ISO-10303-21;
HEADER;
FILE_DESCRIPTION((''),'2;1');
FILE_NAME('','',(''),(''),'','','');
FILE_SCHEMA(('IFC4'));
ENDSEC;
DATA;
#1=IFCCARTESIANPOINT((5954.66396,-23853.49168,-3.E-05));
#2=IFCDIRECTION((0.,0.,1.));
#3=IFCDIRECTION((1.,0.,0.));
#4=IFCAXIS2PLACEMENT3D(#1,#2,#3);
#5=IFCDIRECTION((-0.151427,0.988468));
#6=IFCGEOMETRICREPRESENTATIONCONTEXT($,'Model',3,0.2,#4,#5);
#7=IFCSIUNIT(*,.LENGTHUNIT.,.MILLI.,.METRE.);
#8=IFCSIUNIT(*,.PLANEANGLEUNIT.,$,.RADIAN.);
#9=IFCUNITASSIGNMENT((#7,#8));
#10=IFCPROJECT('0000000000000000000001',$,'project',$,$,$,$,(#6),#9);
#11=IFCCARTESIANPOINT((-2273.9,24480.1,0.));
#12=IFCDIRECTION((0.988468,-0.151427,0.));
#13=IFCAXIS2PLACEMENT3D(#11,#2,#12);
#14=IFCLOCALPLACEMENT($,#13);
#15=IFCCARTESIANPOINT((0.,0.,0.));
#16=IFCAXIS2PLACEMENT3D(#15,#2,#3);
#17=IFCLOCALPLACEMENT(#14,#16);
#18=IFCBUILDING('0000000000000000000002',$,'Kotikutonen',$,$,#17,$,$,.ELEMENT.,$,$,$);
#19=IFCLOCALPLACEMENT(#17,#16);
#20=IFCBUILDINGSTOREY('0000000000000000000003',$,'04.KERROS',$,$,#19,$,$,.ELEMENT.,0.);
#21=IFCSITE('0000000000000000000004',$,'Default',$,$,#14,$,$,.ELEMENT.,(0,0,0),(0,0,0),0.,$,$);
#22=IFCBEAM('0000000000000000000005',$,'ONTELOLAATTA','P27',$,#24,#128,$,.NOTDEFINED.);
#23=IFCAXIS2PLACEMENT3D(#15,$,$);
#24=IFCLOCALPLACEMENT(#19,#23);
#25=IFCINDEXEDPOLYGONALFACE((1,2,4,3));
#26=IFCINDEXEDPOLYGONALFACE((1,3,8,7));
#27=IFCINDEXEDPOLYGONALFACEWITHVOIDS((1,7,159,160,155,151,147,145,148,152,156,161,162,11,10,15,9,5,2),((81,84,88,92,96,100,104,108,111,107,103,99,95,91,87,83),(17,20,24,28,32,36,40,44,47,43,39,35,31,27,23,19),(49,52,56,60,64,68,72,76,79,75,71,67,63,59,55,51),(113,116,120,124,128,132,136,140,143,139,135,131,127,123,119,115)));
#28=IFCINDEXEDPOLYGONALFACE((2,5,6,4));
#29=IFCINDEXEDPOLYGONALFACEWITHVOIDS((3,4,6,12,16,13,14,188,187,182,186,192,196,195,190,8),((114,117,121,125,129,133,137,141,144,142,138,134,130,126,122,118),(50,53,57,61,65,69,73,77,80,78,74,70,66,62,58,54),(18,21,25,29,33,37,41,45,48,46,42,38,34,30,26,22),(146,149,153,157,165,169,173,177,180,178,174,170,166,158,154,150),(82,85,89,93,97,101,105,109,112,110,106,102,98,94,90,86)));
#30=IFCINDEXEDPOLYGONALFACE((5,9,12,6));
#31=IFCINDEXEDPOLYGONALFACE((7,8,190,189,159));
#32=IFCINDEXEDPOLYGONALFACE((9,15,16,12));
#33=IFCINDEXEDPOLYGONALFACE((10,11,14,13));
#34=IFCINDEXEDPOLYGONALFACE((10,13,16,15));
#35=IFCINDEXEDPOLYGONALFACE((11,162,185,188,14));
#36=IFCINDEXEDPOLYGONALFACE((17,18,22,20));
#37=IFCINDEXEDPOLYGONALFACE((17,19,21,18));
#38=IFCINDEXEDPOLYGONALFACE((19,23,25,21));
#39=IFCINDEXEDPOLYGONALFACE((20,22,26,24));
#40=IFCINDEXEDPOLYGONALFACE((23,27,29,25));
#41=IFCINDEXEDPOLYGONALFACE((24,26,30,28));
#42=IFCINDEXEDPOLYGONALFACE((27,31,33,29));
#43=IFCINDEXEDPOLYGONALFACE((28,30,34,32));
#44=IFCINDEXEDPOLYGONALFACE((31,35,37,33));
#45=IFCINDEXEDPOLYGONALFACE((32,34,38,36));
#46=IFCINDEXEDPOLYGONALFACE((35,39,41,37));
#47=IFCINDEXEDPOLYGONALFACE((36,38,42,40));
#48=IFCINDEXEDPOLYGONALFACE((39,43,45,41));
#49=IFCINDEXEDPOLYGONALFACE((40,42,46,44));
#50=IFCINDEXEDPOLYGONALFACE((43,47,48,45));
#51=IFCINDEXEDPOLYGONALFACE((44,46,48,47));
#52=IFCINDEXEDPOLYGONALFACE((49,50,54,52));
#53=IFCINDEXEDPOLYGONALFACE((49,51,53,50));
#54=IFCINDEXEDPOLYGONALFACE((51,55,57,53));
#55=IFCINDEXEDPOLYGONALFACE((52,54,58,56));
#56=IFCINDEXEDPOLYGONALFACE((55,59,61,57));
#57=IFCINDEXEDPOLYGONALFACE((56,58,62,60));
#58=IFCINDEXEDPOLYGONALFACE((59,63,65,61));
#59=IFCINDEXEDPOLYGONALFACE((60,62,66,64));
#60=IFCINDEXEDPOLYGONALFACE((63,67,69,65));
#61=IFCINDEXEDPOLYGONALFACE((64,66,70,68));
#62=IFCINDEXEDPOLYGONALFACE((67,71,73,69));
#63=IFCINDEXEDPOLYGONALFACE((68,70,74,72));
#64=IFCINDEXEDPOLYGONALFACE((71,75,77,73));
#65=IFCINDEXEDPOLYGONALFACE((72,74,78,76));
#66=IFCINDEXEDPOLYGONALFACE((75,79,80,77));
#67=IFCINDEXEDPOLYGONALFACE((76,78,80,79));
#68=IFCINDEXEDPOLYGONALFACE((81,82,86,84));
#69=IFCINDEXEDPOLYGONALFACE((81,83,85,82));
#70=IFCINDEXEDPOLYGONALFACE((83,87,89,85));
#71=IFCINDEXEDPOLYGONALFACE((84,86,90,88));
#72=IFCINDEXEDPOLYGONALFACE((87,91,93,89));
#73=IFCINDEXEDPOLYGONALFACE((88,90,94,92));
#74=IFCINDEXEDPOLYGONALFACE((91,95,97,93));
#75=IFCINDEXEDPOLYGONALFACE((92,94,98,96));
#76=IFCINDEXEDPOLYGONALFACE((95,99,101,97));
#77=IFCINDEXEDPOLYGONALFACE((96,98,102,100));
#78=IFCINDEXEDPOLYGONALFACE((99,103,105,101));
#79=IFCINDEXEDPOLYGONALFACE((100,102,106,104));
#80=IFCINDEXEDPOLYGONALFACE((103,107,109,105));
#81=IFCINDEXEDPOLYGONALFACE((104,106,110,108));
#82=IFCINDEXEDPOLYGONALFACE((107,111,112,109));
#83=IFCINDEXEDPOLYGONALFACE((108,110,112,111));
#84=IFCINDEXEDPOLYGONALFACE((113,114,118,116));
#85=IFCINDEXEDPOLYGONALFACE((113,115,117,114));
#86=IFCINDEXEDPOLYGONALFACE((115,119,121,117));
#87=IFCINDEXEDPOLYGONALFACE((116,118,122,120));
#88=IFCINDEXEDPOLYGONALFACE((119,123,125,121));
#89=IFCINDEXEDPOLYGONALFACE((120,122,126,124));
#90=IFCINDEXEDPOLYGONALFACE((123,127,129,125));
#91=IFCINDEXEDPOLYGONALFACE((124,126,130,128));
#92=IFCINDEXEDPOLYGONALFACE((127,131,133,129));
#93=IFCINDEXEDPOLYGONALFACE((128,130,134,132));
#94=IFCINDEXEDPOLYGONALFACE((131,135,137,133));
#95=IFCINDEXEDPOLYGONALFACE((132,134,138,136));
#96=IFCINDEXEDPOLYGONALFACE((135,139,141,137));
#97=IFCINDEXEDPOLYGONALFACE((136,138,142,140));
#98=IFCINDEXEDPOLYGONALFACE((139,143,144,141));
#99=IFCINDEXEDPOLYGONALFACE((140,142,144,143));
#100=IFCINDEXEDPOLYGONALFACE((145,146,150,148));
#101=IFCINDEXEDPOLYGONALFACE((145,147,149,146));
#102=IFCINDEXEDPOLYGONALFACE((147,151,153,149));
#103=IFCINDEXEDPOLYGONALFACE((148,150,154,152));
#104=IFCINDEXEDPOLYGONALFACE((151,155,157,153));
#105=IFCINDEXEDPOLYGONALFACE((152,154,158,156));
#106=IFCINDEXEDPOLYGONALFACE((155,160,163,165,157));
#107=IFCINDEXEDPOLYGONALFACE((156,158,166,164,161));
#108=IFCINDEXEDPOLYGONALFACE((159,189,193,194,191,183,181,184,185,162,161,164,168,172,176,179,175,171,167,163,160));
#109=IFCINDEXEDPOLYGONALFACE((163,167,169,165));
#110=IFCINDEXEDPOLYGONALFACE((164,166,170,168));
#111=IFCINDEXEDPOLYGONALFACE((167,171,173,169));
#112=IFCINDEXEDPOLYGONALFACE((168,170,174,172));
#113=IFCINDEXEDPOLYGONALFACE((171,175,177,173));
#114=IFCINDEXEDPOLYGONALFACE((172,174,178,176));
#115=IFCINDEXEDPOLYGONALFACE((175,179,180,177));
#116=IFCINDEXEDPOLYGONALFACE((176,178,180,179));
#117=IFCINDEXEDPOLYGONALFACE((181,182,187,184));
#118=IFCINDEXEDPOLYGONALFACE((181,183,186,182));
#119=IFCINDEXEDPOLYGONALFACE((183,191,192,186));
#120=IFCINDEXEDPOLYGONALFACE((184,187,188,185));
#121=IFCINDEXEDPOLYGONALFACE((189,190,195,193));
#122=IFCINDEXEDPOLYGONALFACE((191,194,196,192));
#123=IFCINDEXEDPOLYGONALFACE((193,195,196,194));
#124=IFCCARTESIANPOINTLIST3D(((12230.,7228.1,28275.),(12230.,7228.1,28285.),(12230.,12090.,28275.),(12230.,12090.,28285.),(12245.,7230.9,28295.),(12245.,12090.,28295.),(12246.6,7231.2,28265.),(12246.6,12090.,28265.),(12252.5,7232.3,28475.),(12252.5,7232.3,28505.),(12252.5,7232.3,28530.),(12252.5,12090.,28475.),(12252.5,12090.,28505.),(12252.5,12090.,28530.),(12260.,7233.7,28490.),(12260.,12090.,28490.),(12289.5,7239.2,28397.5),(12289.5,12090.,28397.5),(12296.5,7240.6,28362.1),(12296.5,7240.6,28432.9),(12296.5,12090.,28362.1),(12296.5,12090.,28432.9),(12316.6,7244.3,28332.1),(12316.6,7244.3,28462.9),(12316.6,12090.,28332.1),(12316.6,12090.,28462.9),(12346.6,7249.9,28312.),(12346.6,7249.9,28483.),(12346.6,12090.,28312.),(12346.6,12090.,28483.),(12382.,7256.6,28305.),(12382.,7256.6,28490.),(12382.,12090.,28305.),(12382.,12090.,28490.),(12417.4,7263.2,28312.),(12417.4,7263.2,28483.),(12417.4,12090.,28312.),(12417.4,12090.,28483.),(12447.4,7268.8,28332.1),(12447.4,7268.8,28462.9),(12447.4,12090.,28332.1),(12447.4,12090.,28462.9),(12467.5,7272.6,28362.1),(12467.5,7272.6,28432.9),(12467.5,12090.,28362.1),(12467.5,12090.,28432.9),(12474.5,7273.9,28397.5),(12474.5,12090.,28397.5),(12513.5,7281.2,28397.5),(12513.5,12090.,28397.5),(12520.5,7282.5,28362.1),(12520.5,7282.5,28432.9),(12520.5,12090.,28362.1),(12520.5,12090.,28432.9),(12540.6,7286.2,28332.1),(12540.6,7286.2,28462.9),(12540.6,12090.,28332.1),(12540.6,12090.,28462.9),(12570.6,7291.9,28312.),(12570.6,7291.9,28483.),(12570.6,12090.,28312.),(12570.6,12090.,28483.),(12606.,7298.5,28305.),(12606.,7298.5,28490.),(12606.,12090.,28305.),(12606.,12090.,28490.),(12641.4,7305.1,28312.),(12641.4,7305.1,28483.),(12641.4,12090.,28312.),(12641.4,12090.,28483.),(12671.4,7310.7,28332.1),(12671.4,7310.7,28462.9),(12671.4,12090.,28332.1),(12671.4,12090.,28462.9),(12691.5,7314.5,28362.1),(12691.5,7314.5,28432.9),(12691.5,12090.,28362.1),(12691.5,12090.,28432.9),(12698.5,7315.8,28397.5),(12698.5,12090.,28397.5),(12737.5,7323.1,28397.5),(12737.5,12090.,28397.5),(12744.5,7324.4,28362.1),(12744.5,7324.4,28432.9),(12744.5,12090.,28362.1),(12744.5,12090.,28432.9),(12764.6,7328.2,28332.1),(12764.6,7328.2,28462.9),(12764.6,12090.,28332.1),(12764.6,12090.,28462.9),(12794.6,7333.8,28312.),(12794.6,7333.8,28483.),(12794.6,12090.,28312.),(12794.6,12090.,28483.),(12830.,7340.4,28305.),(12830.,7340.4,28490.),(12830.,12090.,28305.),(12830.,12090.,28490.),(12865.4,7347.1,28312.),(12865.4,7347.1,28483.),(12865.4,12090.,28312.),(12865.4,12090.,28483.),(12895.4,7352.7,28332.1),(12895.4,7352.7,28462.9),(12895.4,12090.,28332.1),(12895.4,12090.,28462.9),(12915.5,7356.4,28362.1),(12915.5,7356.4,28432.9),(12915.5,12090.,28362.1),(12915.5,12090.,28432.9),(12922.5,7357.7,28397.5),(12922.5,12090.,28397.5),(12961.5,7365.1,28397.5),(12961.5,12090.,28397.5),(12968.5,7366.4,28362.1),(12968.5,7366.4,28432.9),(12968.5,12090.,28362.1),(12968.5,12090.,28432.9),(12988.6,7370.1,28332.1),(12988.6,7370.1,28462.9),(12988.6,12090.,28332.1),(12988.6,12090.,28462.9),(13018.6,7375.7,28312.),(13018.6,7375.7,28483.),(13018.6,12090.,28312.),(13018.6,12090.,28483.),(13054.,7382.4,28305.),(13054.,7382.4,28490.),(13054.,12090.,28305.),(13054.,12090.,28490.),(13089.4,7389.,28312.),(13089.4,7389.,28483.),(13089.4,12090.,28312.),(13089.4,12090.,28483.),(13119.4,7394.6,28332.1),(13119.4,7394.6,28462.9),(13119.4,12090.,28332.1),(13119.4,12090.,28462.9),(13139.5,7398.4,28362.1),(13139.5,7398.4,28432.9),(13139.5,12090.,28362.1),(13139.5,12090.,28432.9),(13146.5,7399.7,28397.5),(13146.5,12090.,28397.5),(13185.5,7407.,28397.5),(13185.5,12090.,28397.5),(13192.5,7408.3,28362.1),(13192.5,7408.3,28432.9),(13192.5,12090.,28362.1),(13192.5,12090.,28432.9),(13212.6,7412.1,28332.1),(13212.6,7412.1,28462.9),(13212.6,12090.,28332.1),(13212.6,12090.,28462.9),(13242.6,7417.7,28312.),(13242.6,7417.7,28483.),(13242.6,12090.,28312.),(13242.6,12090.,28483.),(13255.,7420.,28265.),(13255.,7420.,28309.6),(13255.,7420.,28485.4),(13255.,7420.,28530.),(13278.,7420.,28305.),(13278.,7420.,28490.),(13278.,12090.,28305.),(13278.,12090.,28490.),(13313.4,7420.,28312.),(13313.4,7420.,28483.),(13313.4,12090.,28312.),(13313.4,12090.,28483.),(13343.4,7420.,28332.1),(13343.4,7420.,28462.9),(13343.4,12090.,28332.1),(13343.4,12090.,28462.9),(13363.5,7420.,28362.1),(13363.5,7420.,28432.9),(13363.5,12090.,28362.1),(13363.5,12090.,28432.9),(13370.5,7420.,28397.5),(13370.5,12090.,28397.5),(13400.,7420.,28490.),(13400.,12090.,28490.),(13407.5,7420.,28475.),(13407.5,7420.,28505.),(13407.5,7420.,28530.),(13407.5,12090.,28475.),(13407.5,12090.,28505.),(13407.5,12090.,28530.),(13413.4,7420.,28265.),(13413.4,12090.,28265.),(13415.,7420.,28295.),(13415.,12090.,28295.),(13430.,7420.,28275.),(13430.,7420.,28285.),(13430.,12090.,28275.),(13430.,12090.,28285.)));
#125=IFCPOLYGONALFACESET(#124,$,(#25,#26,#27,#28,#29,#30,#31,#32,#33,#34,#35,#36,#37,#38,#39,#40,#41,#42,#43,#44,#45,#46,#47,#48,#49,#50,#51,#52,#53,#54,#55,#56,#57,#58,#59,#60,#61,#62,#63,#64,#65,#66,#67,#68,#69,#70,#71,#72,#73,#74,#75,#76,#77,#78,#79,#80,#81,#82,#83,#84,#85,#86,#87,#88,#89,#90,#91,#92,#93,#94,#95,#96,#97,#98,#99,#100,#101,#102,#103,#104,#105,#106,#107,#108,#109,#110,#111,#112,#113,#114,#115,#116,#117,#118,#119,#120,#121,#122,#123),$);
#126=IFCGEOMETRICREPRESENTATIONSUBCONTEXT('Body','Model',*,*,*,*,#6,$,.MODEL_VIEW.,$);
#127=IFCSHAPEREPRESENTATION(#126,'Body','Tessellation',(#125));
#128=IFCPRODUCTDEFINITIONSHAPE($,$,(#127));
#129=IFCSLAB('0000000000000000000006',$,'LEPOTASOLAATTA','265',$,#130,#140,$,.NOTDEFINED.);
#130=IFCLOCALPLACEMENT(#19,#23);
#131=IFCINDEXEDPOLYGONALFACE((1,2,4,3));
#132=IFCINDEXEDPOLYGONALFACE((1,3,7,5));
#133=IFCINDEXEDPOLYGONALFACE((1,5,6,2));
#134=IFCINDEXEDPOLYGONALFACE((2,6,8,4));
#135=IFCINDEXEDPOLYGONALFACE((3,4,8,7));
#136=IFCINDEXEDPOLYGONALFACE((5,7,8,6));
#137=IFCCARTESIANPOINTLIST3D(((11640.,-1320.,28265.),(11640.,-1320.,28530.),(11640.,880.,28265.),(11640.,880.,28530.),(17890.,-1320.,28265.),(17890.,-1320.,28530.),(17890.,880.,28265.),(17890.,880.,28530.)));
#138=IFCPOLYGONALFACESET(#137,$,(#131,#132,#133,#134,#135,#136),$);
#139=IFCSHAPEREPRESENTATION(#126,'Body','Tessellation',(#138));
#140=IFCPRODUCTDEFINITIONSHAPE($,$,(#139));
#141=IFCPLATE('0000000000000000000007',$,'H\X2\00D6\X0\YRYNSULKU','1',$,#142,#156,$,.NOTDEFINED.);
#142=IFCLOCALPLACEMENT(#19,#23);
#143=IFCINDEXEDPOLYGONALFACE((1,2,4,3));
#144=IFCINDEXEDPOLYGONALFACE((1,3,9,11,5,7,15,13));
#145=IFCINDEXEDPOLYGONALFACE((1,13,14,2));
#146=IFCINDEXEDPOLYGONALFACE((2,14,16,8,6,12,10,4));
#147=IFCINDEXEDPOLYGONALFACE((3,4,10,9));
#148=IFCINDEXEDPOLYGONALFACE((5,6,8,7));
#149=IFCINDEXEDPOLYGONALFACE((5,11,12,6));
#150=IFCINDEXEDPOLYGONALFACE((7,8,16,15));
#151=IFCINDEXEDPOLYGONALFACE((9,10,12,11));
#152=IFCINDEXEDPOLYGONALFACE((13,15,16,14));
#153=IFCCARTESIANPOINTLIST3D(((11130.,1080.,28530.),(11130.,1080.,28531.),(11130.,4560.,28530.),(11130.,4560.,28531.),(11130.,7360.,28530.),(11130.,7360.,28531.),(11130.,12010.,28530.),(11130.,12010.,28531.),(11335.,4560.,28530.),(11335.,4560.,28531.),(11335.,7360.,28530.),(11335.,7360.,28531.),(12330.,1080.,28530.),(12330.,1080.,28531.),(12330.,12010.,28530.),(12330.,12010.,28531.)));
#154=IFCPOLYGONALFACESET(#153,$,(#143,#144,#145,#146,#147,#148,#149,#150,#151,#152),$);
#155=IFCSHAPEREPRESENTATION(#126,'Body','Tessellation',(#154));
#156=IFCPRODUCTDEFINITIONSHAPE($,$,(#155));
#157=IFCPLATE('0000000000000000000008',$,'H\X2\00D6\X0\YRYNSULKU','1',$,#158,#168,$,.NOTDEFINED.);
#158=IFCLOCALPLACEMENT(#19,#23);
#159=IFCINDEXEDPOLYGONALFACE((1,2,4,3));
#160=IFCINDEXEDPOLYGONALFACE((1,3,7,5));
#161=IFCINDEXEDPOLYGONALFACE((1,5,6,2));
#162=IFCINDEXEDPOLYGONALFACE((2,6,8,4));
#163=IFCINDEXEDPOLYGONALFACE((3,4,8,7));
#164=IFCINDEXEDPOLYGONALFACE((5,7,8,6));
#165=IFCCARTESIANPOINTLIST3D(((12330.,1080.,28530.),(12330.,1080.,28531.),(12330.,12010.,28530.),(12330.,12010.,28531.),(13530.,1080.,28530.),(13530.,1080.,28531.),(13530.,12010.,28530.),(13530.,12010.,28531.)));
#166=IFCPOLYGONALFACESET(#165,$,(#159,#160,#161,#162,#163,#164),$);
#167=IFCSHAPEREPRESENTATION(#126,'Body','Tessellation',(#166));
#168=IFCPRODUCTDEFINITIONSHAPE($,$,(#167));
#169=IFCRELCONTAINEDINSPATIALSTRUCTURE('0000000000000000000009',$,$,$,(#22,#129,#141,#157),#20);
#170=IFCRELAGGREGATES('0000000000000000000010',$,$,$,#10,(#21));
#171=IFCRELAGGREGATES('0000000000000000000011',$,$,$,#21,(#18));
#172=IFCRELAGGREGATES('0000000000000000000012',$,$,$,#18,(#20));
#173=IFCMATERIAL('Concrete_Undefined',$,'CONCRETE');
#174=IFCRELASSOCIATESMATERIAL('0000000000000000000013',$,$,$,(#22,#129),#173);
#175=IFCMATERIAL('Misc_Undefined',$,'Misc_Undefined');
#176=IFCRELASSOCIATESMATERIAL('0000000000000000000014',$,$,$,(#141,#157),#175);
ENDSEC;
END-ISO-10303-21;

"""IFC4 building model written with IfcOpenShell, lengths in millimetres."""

from ifc_helpers import new_model, si_unit, direction, frame, origin_with_axes, place, context, subcontext, project, spatial, line, indexed_curve, outline, extrude, material, element, save


model = new_model("IFC4")

# Units and contexts
model_context = context("Model", 3, precision=0.2, world=frame((5954.66396, -23853.49168, -3e-05), z_axis=(0.0, 0.0, 1.0), x_axis=(1.0, 0.0, 0.0)), true_north=direction((-0.151427, 0.988468)))
body_context = subcontext(model_context, "Body", "Model", "MODEL_VIEW")
ifc_project = project(units=[si_unit("LENGTHUNIT", "METRE", prefix="MILLI"), si_unit("PLANEANGLEUNIT", "RADIAN")], contexts=[model_context])

# Site, building, storey
site_placement = place(None, frame((-2273.9, 24480.1, 0.0), z_axis=(0.0, 0.0, 1.0), x_axis=(0.988468, -0.151427, 0.0)))
site = spatial("IfcSite", under=ifc_project, at=site_placement, Name="Default", CompositionType="ELEMENT", RefLatitude=(0, 0, 0), RefLongitude=(0, 0, 0), RefElevation=0.0)
building_placement = place(site_placement, origin_with_axes())
building = spatial("IfcBuilding", under=site, at=building_placement, Name="Kotikutonen", CompositionType="ELEMENT")
storey_placement = place(building_placement, origin_with_axes())
storey = spatial("IfcBuildingStorey", under=building, at=storey_placement, Name="04.KERROS", CompositionType="ELEMENT", Elevation=0.0)

# Shared definitions
ifc_material_1 = material(Name="Concrete_Undefined", Category="CONCRETE")

# Beam, voiding feature
beam_1_placement = place(storey_placement, frame((12830.0, 12090.0, 28397.5), z_axis=(-1.0, 0.0, 0.0), x_axis=(0.0, -1.0, 0.0)))
beam_1 = element("IfcBeam", 1, at=beam_1_placement, inside=storey, material=ifc_material_1, Name="ONTELOLAATTA", Description="P27", PredefinedType="NOTDEFINED", context=body_context, shape_type="SolidModel", body=[
    extrude(outline(indexed_curve([(-600.0, -122.5), (-583.4, -132.5), (583.4, -132.5), (600.0, -122.5), (600.0, -112.5), (585.0, -102.5), (577.5, 77.5), (570.0, 92.5), (577.5, 107.5), (577.5, 132.5), (-577.5, 132.5), (-577.5, 107.5), (-570.0, 92.5), (-577.5, 77.5), (-585.0, -102.5), (-600.0, -112.5)], segments=[line(1, 2, 3, 4, 5, 6, 7, 8, 9, 10, 11, 12, 13, 14, 15, 16, 1)]), holes=[indexed_curve([(-448.0, -92.5), (-483.4, -85.5), (-513.4, -65.4), (-533.5, -35.4), (-540.5, 0.0), (-533.5, 35.4), (-513.4, 65.4), (-483.4, 85.5), (-448.0, 92.5), (-412.6, 85.5), (-382.6, 65.4), (-362.5, 35.4), (-355.5, 0.0), (-362.5, -35.4), (-382.6, -65.4), (-412.6, -85.5)], segments=[line(1, 2, 3, 4, 5, 6, 7, 8, 9, 10, 11, 12, 13, 14, 15, 16, 1)]), indexed_curve([(-224.0, -92.5), (-259.4, -85.5), (-289.4, -65.4), (-309.5, -35.4), (-316.5, 0.0), (-309.5, 35.4), (-289.4, 65.4), (-259.4, 85.5), (-224.0, 92.5), (-188.6, 85.5), (-158.6, 65.4), (-138.5, 35.4), (-131.5, 0.0), (-138.5, -35.4), (-158.6, -65.4), (-188.6, -85.5)], segments=[line(1, 2, 3, 4, 5, 6, 7, 8, 9, 10, 11, 12, 13, 14, 15, 16, 1)]), indexed_curve([(0.0, -92.5), (-35.4, -85.5), (-65.4, -65.4), (-85.5, -35.4), (-92.5, 0.0), (-85.5, 35.4), (-65.4, 65.4), (-35.4, 85.5), (0.0, 92.5), (35.4, 85.5), (65.4, 65.4), (85.5, 35.4), (92.5, 0.0), (85.5, -35.4), (65.4, -65.4), (35.4, -85.5)], segments=[line(1, 2, 3, 4, 5, 6, 7, 8, 9, 10, 11, 12, 13, 14, 15, 16, 1)]), indexed_curve([(224.0, -92.5), (188.6, -85.5), (158.6, -65.4), (138.5, -35.4), (131.5, 0.0), (138.5, 35.4), (158.6, 65.4), (188.6, 85.5), (224.0, 92.5), (259.4, 85.5), (289.4, 65.4), (309.5, 35.4), (316.5, 0.0), (309.5, -35.4), (289.4, -65.4), (259.4, -85.5)], segments=[line(1, 2, 3, 4, 5, 6, 7, 8, 9, 10, 11, 12, 13, 14, 15, 16, 1)]), indexed_curve([(448.0, -92.5), (412.6, -85.5), (382.6, -65.4), (362.5, -35.4), (355.5, 0.0), (362.5, 35.4), (382.6, 65.4), (412.6, 85.5), (448.0, 92.5), (483.4, 85.5), (513.4, 65.4), (533.5, 35.4), (540.5, 0.0), (533.5, -35.4), (513.4, -65.4), (483.4, -85.5)], segments=[line(1, 2, 3, 4, 5, 6, 7, 8, 9, 10, 11, 12, 13, 14, 15, 16, 1)])]), frame((0.0, 0.0, 0.0), z_axis=(-1.0, 0.0, 0.0), x_axis=(0.0, 0.0, 1.0)), (0.0, 0.0, -1.0), 4861.9),
])
voiding_feature_1_placement = place(beam_1_placement, frame((4670.0, 0.0, -425.0), z_axis=(0.0, 1.0, 0.0), x_axis=(0.184024, 0.0, 0.982922)))
element("IfcVoidingFeature", 2, at=voiding_feature_1_placement, cuts=beam_1, Name="Opening", PredefinedType="HOLE", context=body_context, shape_type="SolidModel", body=[
    extrude(outline(indexed_curve([(0.0, 0.0), (1297.2, 0.0), (1334.5, 199.7), (-336.4, 512.6), (-417.7, 78.2)], segments=[line(1, 2, 3, 4, 5, 1)])), frame((0.0, 0.0, 207.5), z_axis=(0.0, 0.0, 1.0), x_axis=(1.0, 0.0, 0.0)), (0.0, 0.0, -1.0), 415.0),
])

# Slab
slab_1_placement = place(storey_placement, frame((11640.0, 880.0, 28397.5), z_axis=(0.0, 0.0, 1.0), x_axis=(0.0, -1.0, 0.0)))
element("IfcSlab", 3, at=slab_1_placement, inside=storey, material=ifc_material_1, Name="LEPOTASOLAATTA", Description="265", PredefinedType="NOTDEFINED", context=body_context, shape_type="SolidModel", body=[
    extrude(outline(indexed_curve([(0.0, 0.0), (2200.0, 0.0), (2200.0, 6250.0), (0.0, 6250.0)], segments=[line(1, 2, 3, 4, 1)])), frame((0.0, 0.0, 132.5), z_axis=(0.0, 0.0, 1.0), x_axis=(1.0, 0.0, 0.0)), (0.0, 0.0, -1.0), 265.0),
])

# Plates
ifc_material_2 = material(Name="Misc_Undefined", Category="Misc_Undefined")
plate_1_placement = place(storey_placement, frame((12330.0, 1080.0, 28530.5), z_axis=(0.0, 0.0, 1.0), x_axis=(0.0, 1.0, 0.0)))
element("IfcPlate", 4, at=plate_1_placement, inside=storey, material=ifc_material_2, Name="HÖYRYNSULKU", Description="1", PredefinedType="NOTDEFINED", context=body_context, shape_type="SolidModel", body=[
    extrude(outline(indexed_curve([(0.0, 0.0), (10930.0, 0.0), (10930.0, 1200.0), (6280.0, 1200.0), (6280.0, 995.0), (3480.0, 995.0), (3480.0, 1200.0), (0.0, 1200.0)], segments=[line(1, 2, 3, 4, 5, 6, 7, 8, 1)])), frame((0.0, 0.0, 0.5), z_axis=(0.0, 0.0, 1.0), x_axis=(1.0, 0.0, 0.0)), (0.0, 0.0, -1.0), 1.0),
])
plate_2_placement = place(storey_placement, frame((12330.0, 1080.0, 28530.5), z_axis=(0.0, 0.0, 1.0), x_axis=(1.0, 0.0, 0.0)))
element("IfcPlate", 5, at=plate_2_placement, inside=storey, material=ifc_material_2, Name="HÖYRYNSULKU", Description="1", PredefinedType="NOTDEFINED", context=body_context, shape_type="SolidModel", body=[
    extrude(outline(indexed_curve([(0.0, 0.0), (1200.0, 0.0), (1200.0, 10930.0), (0.0, 10930.0)], segments=[line(1, 2, 3, 4, 1)])), frame((0.0, 0.0, 0.5), z_axis=(0.0, 0.0, 1.0), x_axis=(1.0, 0.0, 0.0)), (0.0, 0.0, -1.0), 1.0),
])

save(model, "model.ifc")
